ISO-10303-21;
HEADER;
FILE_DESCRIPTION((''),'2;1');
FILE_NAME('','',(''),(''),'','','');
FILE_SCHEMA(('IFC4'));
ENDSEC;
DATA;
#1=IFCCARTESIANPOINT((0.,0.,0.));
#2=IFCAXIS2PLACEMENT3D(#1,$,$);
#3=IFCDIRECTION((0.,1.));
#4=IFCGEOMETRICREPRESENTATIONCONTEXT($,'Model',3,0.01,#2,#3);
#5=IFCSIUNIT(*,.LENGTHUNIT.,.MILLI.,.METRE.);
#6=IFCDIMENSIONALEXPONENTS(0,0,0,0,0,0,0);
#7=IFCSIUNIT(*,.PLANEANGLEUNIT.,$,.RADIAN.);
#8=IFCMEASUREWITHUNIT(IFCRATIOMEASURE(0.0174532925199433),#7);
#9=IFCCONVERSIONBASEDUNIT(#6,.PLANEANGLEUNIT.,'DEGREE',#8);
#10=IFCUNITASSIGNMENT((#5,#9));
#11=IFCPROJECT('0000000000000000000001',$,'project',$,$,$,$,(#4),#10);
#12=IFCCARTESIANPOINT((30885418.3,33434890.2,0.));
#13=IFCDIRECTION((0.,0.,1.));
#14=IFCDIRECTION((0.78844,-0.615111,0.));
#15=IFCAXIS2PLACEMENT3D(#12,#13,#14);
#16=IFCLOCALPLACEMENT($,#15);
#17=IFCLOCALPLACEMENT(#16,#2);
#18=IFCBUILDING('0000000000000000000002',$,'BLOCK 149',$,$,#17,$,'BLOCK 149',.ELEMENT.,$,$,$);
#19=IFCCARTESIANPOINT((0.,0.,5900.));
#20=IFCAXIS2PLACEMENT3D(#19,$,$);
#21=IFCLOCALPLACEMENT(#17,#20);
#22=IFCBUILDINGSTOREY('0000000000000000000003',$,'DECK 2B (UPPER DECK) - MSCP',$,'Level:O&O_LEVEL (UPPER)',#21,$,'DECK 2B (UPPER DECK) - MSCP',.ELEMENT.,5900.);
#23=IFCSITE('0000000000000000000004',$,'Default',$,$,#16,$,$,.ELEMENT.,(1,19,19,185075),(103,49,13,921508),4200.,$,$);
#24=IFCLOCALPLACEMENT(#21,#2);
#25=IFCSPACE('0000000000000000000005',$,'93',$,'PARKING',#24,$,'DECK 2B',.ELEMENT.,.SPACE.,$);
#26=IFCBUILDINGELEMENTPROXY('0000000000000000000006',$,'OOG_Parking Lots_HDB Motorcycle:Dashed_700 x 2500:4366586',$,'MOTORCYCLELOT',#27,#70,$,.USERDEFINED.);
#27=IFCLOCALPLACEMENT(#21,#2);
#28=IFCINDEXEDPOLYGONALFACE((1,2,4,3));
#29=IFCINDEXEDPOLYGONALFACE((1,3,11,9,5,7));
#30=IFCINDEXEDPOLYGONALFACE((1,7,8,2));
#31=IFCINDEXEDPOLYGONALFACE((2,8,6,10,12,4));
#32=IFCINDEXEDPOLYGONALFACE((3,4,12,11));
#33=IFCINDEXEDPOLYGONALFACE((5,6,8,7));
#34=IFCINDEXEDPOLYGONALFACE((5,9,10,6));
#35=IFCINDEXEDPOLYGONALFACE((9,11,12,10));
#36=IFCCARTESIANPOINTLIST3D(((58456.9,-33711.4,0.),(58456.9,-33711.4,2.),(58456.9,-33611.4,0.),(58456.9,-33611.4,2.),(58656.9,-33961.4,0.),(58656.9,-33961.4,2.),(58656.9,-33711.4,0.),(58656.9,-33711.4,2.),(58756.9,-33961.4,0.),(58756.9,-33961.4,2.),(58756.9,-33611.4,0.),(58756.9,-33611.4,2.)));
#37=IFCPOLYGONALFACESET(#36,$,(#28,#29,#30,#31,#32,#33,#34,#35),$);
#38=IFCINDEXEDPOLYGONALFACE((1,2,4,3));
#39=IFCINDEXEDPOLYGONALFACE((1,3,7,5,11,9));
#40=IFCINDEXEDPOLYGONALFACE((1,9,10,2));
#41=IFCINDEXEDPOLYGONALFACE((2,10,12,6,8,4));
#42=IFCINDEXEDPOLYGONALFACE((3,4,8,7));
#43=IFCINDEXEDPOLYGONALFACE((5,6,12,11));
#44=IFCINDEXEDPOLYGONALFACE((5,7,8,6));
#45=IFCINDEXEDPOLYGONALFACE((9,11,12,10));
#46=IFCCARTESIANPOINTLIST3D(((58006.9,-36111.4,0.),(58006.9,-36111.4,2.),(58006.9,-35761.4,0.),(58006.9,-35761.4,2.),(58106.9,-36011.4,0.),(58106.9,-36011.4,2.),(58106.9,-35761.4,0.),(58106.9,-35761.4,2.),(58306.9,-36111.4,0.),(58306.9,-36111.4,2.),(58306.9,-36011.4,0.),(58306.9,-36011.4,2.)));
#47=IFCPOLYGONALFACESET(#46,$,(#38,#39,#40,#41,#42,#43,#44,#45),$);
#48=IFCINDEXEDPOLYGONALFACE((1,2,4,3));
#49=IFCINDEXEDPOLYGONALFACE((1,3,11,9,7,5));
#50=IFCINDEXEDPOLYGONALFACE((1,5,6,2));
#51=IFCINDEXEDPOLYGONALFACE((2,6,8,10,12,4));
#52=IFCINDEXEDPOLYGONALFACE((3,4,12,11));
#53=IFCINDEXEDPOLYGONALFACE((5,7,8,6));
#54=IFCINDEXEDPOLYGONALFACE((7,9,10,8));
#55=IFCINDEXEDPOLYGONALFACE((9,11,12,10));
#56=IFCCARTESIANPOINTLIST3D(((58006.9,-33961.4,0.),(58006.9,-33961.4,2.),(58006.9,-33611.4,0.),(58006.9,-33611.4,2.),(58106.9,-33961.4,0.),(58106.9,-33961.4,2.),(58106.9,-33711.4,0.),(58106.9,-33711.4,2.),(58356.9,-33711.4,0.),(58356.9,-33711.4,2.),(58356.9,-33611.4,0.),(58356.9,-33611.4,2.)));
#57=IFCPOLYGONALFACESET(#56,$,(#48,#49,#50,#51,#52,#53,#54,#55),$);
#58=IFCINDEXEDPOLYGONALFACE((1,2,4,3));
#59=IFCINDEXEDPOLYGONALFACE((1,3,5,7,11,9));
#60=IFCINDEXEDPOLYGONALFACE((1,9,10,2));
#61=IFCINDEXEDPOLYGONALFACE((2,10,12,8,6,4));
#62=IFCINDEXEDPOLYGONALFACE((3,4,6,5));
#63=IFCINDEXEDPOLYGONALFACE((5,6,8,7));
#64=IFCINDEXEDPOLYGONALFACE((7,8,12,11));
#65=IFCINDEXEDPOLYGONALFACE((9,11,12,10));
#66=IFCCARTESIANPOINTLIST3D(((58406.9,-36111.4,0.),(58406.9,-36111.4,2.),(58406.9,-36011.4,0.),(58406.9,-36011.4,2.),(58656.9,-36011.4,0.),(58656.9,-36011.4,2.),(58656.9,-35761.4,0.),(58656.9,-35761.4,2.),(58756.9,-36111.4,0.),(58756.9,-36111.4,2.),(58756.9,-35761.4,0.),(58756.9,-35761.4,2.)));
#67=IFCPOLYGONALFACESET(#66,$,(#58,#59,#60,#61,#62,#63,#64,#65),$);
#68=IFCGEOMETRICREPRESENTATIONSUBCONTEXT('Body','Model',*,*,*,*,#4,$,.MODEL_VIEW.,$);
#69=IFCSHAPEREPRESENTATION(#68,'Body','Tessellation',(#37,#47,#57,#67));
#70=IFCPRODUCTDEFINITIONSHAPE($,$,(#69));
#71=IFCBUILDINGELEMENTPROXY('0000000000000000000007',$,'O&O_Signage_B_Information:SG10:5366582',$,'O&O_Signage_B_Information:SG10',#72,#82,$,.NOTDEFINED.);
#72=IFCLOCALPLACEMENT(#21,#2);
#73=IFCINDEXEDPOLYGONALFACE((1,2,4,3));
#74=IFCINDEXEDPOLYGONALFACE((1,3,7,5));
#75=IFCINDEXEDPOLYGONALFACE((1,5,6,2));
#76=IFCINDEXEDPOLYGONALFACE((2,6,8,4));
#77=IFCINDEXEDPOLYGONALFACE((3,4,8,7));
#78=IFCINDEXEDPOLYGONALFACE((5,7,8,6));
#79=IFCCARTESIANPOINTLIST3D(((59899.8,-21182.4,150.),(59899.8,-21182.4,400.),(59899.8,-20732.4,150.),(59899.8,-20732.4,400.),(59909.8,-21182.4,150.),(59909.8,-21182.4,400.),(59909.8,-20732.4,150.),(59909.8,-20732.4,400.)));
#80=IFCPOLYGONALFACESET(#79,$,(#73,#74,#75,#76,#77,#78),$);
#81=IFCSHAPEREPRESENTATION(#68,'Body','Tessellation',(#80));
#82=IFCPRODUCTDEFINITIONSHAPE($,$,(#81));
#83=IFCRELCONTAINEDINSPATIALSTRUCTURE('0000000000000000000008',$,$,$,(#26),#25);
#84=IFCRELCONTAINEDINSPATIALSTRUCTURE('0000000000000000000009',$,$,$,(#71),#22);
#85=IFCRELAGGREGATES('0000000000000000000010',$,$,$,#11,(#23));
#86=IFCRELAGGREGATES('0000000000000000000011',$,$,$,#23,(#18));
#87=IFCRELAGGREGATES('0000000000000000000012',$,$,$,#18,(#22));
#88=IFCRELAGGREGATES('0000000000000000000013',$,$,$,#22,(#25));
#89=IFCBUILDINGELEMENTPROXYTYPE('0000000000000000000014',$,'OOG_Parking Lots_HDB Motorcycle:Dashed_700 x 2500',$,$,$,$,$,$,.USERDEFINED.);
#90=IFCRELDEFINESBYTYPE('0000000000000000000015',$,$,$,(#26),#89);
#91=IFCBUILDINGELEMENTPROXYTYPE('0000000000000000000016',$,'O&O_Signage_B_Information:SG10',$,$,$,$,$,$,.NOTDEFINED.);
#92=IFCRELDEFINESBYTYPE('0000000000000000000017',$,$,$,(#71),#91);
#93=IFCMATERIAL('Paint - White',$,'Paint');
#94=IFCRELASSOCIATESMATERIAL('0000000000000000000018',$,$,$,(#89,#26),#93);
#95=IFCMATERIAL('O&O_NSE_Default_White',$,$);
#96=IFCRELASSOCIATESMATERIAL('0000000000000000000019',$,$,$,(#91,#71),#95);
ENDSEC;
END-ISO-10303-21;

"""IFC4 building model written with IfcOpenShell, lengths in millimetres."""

from ifc_helpers import new_model, entity, si_unit, converted_unit, direction, frame, origin, place, context, subcontext, project, spatial, indexed_curve, outline, extrude, source, transform, mapped, material, type_object, type_shapes, element, save


model = new_model("IFC4")

# Units and contexts
model_context = context("Model", 3, precision=0.01, world=origin(), true_north=direction((0.0, 1.0)))
body_context = subcontext(model_context, "Body", "Model", "MODEL_VIEW")
ifc_project = project(units=[si_unit("LENGTHUNIT", "METRE", prefix="MILLI"), converted_unit("PLANEANGLEUNIT", "DEGREE", entity("IfcRatioMeasure", 0.0174532925199433), si_unit("PLANEANGLEUNIT", "RADIAN"), dimensions=[0, 0, 0, 0, 0, 0, 0])], contexts=[model_context])

# Site, building, storey
site_placement = place(None, frame((30885418.3, 33434890.2, 0.0), z_axis=(0.0, 0.0, 1.0), x_axis=(0.78844, -0.615111, 0.0)))
site = spatial("IfcSite", under=ifc_project, at=site_placement, Name="Default", CompositionType="ELEMENT", RefLatitude=(1, 19, 19, 185075), RefLongitude=(103, 49, 13, 921508), RefElevation=4200.0)
building_placement = place(site_placement, origin())
building = spatial("IfcBuilding", under=site, at=building_placement, Name="BLOCK 149", LongName="BLOCK 149", CompositionType="ELEMENT")
storey_placement = place(building_placement, frame((0.0, 0.0, 5900.0)))
storey = spatial("IfcBuildingStorey", under=building, at=storey_placement, Name="DECK 2B (UPPER DECK) - MSCP", ObjectType="Level:O&O_LEVEL (UPPER)", LongName="DECK 2B (UPPER DECK) - MSCP", CompositionType="ELEMENT", Elevation=5900.0)

# Shared definitions
space_placement = place(storey_placement, origin())
space = spatial("IfcSpace", under=storey, at=space_placement, Name="93", ObjectType="PARKING", LongName="DECK 2B", CompositionType="ELEMENT", PredefinedType="SPACE")

# Building element proxies
ifc_material_1 = material(Name="Paint - White", Category="Paint")
building_element_proxy_type_1 = type_object("IfcBuildingElementProxyType", Name="OOG_Parking Lots_HDB Motorcycle:Dashed_700 x 2500", PredefinedType="USERDEFINED", material=ifc_material_1)
shared_shape_1 = source(origin(), body_context, "Body", "SweptSolid", [
    extrude(outline(indexed_curve([(-200.0, -133.3), (150.0, -133.3), (150.0, 166.7), (50.0, 166.7), (50.0, -33.3), (-200.0, -33.3), (-200.0, -133.3)], self_intersect=False)), frame((566.7, -100.0, 0.0), z_axis=(0.0, 0.0, 1.0), x_axis=(0.0, 1.0, 0.0)), (0.0, 0.0, 1.0), 2.0),
    extrude(outline(indexed_curve([(-200.0, -133.3), (150.0, -133.3), (150.0, 166.7), (50.0, 166.7), (50.0, -33.3), (-200.0, -33.3), (-200.0, -133.3)], self_intersect=False)), frame((83.3, -2300.0, 0.0), z_axis=(0.0, 0.0, 1.0), x_axis=(0.0, -1.0, 0.0)), (0.0, 0.0, 1.0), 2.0),
    extrude(outline(indexed_curve([(-200.0, -150.0), (150.0, -150.0), (150.0, 200.0), (50.0, 200.0), (50.0, -50.0), (-200.0, -50.0), (-200.0, -150.0)], self_intersect=False)), frame((100.0, -100.0, 0.0), z_axis=(0.0, 0.0, 1.0), x_axis=(-1.0, 0.0, 0.0)), (0.0, 0.0, 1.0), 2.0),
    extrude(outline(indexed_curve([(-200.0, -150.0), (150.0, -150.0), (150.0, 200.0), (50.0, 200.0), (50.0, -50.0), (-200.0, -50.0), (-200.0, -150.0)], self_intersect=False)), frame((550.0, -2300.0, 0.0)), (0.0, 0.0, 1.0), 2.0),
])
type_shapes(building_element_proxy_type_1, [shared_shape_1])
proxy_1_placement = place(space_placement, frame((58056.9, -33661.4, 0.0)))
element("IfcBuildingElementProxy", 1, at=proxy_1_placement, inside=space, type_object=building_element_proxy_type_1, material=ifc_material_1, Name="OOG_Parking Lots_HDB Motorcycle:Dashed_700 x 2500:4366586", ObjectType="MOTORCYCLELOT", PredefinedType="USERDEFINED", context=body_context, shape_type="MappedRepresentation", body=[
    mapped(shared_shape_1, transform((0.0, 0.0, 0.0), scale=1.0)),
])
ifc_material_2 = material(Name="O&O_NSE_Default_White")
building_element_proxy_type_2 = type_object("IfcBuildingElementProxyType", Name="O&O_Signage_B_Information:SG10", PredefinedType="NOTDEFINED", material=ifc_material_2)
shared_shape_2 = source(origin(), body_context, "Body", "SweptSolid", [
    extrude(outline(indexed_curve([(-5.0, -225.0), (5.0, -225.0), (5.0, 225.0), (-5.0, 225.0), (-5.0, -225.0)], self_intersect=False)), frame((0.0, 5.0, 150.0), z_axis=(0.0, 0.0, 1.0), x_axis=(0.0, 1.0, 0.0)), (0.0, 0.0, 1.0), 250.0),
])
type_shapes(building_element_proxy_type_2, [shared_shape_2])
proxy_2_placement = place(storey_placement, frame((59899.8, -20957.4, 0.0), z_axis=(0.0, 0.0, 1.0), x_axis=(0.000001, -1.0, 0.0)))
element("IfcBuildingElementProxy", 2, at=proxy_2_placement, inside=storey, type_object=building_element_proxy_type_2, material=ifc_material_2, Name="O&O_Signage_B_Information:SG10:5366582", ObjectType="O&O_Signage_B_Information:SG10", PredefinedType="NOTDEFINED", context=body_context, shape_type="MappedRepresentation", body=[
    mapped(shared_shape_2, transform((0.0, 0.0, 0.0), scale=1.0)),
])

save(model, "model.ifc")
